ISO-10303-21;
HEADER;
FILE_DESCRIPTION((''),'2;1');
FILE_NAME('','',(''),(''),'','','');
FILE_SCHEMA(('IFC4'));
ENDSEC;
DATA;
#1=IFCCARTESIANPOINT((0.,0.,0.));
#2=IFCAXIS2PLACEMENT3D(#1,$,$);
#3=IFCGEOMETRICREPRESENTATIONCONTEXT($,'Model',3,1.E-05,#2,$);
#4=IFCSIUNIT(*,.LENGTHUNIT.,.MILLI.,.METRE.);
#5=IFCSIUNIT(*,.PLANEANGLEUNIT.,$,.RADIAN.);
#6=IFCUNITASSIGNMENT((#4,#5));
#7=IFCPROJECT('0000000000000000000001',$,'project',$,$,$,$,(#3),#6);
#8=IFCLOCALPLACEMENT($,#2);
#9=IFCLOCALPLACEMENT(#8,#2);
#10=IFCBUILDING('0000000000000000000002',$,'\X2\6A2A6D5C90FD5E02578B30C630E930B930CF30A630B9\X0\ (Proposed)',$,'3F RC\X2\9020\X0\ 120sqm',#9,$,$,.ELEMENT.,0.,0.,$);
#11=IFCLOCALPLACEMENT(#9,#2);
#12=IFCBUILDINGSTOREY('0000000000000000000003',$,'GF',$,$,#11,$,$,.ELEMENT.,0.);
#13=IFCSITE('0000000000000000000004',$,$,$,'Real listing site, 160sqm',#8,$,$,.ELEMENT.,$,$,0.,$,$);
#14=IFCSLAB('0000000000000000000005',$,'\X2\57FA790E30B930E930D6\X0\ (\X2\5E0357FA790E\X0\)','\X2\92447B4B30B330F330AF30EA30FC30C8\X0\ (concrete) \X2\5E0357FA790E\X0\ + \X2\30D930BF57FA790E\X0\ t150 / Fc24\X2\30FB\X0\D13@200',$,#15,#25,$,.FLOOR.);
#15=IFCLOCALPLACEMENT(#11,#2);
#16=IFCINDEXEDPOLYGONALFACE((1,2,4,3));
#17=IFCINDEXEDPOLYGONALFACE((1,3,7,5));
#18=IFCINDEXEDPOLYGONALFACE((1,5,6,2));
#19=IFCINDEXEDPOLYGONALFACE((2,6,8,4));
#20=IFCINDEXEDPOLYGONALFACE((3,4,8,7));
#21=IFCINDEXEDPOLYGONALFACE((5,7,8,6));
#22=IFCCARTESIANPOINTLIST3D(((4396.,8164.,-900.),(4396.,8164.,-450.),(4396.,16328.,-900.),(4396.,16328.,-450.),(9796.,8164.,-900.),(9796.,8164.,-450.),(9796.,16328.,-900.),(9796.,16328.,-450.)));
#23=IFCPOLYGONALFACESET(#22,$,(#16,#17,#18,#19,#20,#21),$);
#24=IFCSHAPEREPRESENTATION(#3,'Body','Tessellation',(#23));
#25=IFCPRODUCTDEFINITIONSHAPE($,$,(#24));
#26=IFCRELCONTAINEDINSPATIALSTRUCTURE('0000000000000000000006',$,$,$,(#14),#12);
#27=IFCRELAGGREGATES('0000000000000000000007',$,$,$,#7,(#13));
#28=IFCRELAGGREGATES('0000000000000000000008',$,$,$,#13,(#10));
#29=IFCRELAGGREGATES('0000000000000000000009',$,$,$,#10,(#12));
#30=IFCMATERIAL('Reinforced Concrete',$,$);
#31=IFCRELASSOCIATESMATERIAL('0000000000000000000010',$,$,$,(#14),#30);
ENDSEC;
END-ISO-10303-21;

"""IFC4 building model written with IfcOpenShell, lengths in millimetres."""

from ifc_helpers import new_model, si_unit, frame, frame_2d, origin, place, context, project, spatial, rectangle, extrude, material, element, save


model = new_model("IFC4")

# Units and contexts
model_context = context("Model", 3, precision=1e-05, world=origin())
ifc_project = project(units=[si_unit("LENGTHUNIT", "METRE", prefix="MILLI"), si_unit("PLANEANGLEUNIT", "RADIAN")], contexts=[model_context])

# Site, building, storey
site_placement = place(None, origin())
site = spatial("IfcSite", under=ifc_project, at=site_placement, ObjectType="Real listing site, 160sqm", CompositionType="ELEMENT", RefElevation=0.0)
building_placement = place(site_placement, origin())
building = spatial("IfcBuilding", under=site, at=building_placement, Name="横浜都市型テラスハウス (Proposed)", ObjectType="3F RC造 120sqm", CompositionType="ELEMENT", ElevationOfRefHeight=0.0, ElevationOfTerrain=0.0)
storey_placement = place(building_placement, origin())
storey = spatial("IfcBuildingStorey", under=building, at=storey_placement, Name="GF", CompositionType="ELEMENT", Elevation=0.0)

# Slab
ifc_material_1 = material(Name="Reinforced Concrete")
slab_1_placement = place(storey_placement, frame((2198.0, 4082.0, -450.0)))
element("IfcSlab", 1, at=slab_1_placement, inside=storey, material=ifc_material_1, Name="基礎スラブ (布基礎)", Description="鉄筋コンクリート (concrete) 布基礎 + ベタ基礎 t150 / Fc24・D13@200", PredefinedType="FLOOR", context=model_context, shape_type="SweptSolid", body=[
    extrude(rectangle(XDim=5400.0, YDim=8164.0, at=frame_2d((2700.0, 4082.0))), frame((2198.0, 4082.0, -450.0)), (0.0, 0.0, 1.0), 450.0),
])

save(model, "model.ifc")
